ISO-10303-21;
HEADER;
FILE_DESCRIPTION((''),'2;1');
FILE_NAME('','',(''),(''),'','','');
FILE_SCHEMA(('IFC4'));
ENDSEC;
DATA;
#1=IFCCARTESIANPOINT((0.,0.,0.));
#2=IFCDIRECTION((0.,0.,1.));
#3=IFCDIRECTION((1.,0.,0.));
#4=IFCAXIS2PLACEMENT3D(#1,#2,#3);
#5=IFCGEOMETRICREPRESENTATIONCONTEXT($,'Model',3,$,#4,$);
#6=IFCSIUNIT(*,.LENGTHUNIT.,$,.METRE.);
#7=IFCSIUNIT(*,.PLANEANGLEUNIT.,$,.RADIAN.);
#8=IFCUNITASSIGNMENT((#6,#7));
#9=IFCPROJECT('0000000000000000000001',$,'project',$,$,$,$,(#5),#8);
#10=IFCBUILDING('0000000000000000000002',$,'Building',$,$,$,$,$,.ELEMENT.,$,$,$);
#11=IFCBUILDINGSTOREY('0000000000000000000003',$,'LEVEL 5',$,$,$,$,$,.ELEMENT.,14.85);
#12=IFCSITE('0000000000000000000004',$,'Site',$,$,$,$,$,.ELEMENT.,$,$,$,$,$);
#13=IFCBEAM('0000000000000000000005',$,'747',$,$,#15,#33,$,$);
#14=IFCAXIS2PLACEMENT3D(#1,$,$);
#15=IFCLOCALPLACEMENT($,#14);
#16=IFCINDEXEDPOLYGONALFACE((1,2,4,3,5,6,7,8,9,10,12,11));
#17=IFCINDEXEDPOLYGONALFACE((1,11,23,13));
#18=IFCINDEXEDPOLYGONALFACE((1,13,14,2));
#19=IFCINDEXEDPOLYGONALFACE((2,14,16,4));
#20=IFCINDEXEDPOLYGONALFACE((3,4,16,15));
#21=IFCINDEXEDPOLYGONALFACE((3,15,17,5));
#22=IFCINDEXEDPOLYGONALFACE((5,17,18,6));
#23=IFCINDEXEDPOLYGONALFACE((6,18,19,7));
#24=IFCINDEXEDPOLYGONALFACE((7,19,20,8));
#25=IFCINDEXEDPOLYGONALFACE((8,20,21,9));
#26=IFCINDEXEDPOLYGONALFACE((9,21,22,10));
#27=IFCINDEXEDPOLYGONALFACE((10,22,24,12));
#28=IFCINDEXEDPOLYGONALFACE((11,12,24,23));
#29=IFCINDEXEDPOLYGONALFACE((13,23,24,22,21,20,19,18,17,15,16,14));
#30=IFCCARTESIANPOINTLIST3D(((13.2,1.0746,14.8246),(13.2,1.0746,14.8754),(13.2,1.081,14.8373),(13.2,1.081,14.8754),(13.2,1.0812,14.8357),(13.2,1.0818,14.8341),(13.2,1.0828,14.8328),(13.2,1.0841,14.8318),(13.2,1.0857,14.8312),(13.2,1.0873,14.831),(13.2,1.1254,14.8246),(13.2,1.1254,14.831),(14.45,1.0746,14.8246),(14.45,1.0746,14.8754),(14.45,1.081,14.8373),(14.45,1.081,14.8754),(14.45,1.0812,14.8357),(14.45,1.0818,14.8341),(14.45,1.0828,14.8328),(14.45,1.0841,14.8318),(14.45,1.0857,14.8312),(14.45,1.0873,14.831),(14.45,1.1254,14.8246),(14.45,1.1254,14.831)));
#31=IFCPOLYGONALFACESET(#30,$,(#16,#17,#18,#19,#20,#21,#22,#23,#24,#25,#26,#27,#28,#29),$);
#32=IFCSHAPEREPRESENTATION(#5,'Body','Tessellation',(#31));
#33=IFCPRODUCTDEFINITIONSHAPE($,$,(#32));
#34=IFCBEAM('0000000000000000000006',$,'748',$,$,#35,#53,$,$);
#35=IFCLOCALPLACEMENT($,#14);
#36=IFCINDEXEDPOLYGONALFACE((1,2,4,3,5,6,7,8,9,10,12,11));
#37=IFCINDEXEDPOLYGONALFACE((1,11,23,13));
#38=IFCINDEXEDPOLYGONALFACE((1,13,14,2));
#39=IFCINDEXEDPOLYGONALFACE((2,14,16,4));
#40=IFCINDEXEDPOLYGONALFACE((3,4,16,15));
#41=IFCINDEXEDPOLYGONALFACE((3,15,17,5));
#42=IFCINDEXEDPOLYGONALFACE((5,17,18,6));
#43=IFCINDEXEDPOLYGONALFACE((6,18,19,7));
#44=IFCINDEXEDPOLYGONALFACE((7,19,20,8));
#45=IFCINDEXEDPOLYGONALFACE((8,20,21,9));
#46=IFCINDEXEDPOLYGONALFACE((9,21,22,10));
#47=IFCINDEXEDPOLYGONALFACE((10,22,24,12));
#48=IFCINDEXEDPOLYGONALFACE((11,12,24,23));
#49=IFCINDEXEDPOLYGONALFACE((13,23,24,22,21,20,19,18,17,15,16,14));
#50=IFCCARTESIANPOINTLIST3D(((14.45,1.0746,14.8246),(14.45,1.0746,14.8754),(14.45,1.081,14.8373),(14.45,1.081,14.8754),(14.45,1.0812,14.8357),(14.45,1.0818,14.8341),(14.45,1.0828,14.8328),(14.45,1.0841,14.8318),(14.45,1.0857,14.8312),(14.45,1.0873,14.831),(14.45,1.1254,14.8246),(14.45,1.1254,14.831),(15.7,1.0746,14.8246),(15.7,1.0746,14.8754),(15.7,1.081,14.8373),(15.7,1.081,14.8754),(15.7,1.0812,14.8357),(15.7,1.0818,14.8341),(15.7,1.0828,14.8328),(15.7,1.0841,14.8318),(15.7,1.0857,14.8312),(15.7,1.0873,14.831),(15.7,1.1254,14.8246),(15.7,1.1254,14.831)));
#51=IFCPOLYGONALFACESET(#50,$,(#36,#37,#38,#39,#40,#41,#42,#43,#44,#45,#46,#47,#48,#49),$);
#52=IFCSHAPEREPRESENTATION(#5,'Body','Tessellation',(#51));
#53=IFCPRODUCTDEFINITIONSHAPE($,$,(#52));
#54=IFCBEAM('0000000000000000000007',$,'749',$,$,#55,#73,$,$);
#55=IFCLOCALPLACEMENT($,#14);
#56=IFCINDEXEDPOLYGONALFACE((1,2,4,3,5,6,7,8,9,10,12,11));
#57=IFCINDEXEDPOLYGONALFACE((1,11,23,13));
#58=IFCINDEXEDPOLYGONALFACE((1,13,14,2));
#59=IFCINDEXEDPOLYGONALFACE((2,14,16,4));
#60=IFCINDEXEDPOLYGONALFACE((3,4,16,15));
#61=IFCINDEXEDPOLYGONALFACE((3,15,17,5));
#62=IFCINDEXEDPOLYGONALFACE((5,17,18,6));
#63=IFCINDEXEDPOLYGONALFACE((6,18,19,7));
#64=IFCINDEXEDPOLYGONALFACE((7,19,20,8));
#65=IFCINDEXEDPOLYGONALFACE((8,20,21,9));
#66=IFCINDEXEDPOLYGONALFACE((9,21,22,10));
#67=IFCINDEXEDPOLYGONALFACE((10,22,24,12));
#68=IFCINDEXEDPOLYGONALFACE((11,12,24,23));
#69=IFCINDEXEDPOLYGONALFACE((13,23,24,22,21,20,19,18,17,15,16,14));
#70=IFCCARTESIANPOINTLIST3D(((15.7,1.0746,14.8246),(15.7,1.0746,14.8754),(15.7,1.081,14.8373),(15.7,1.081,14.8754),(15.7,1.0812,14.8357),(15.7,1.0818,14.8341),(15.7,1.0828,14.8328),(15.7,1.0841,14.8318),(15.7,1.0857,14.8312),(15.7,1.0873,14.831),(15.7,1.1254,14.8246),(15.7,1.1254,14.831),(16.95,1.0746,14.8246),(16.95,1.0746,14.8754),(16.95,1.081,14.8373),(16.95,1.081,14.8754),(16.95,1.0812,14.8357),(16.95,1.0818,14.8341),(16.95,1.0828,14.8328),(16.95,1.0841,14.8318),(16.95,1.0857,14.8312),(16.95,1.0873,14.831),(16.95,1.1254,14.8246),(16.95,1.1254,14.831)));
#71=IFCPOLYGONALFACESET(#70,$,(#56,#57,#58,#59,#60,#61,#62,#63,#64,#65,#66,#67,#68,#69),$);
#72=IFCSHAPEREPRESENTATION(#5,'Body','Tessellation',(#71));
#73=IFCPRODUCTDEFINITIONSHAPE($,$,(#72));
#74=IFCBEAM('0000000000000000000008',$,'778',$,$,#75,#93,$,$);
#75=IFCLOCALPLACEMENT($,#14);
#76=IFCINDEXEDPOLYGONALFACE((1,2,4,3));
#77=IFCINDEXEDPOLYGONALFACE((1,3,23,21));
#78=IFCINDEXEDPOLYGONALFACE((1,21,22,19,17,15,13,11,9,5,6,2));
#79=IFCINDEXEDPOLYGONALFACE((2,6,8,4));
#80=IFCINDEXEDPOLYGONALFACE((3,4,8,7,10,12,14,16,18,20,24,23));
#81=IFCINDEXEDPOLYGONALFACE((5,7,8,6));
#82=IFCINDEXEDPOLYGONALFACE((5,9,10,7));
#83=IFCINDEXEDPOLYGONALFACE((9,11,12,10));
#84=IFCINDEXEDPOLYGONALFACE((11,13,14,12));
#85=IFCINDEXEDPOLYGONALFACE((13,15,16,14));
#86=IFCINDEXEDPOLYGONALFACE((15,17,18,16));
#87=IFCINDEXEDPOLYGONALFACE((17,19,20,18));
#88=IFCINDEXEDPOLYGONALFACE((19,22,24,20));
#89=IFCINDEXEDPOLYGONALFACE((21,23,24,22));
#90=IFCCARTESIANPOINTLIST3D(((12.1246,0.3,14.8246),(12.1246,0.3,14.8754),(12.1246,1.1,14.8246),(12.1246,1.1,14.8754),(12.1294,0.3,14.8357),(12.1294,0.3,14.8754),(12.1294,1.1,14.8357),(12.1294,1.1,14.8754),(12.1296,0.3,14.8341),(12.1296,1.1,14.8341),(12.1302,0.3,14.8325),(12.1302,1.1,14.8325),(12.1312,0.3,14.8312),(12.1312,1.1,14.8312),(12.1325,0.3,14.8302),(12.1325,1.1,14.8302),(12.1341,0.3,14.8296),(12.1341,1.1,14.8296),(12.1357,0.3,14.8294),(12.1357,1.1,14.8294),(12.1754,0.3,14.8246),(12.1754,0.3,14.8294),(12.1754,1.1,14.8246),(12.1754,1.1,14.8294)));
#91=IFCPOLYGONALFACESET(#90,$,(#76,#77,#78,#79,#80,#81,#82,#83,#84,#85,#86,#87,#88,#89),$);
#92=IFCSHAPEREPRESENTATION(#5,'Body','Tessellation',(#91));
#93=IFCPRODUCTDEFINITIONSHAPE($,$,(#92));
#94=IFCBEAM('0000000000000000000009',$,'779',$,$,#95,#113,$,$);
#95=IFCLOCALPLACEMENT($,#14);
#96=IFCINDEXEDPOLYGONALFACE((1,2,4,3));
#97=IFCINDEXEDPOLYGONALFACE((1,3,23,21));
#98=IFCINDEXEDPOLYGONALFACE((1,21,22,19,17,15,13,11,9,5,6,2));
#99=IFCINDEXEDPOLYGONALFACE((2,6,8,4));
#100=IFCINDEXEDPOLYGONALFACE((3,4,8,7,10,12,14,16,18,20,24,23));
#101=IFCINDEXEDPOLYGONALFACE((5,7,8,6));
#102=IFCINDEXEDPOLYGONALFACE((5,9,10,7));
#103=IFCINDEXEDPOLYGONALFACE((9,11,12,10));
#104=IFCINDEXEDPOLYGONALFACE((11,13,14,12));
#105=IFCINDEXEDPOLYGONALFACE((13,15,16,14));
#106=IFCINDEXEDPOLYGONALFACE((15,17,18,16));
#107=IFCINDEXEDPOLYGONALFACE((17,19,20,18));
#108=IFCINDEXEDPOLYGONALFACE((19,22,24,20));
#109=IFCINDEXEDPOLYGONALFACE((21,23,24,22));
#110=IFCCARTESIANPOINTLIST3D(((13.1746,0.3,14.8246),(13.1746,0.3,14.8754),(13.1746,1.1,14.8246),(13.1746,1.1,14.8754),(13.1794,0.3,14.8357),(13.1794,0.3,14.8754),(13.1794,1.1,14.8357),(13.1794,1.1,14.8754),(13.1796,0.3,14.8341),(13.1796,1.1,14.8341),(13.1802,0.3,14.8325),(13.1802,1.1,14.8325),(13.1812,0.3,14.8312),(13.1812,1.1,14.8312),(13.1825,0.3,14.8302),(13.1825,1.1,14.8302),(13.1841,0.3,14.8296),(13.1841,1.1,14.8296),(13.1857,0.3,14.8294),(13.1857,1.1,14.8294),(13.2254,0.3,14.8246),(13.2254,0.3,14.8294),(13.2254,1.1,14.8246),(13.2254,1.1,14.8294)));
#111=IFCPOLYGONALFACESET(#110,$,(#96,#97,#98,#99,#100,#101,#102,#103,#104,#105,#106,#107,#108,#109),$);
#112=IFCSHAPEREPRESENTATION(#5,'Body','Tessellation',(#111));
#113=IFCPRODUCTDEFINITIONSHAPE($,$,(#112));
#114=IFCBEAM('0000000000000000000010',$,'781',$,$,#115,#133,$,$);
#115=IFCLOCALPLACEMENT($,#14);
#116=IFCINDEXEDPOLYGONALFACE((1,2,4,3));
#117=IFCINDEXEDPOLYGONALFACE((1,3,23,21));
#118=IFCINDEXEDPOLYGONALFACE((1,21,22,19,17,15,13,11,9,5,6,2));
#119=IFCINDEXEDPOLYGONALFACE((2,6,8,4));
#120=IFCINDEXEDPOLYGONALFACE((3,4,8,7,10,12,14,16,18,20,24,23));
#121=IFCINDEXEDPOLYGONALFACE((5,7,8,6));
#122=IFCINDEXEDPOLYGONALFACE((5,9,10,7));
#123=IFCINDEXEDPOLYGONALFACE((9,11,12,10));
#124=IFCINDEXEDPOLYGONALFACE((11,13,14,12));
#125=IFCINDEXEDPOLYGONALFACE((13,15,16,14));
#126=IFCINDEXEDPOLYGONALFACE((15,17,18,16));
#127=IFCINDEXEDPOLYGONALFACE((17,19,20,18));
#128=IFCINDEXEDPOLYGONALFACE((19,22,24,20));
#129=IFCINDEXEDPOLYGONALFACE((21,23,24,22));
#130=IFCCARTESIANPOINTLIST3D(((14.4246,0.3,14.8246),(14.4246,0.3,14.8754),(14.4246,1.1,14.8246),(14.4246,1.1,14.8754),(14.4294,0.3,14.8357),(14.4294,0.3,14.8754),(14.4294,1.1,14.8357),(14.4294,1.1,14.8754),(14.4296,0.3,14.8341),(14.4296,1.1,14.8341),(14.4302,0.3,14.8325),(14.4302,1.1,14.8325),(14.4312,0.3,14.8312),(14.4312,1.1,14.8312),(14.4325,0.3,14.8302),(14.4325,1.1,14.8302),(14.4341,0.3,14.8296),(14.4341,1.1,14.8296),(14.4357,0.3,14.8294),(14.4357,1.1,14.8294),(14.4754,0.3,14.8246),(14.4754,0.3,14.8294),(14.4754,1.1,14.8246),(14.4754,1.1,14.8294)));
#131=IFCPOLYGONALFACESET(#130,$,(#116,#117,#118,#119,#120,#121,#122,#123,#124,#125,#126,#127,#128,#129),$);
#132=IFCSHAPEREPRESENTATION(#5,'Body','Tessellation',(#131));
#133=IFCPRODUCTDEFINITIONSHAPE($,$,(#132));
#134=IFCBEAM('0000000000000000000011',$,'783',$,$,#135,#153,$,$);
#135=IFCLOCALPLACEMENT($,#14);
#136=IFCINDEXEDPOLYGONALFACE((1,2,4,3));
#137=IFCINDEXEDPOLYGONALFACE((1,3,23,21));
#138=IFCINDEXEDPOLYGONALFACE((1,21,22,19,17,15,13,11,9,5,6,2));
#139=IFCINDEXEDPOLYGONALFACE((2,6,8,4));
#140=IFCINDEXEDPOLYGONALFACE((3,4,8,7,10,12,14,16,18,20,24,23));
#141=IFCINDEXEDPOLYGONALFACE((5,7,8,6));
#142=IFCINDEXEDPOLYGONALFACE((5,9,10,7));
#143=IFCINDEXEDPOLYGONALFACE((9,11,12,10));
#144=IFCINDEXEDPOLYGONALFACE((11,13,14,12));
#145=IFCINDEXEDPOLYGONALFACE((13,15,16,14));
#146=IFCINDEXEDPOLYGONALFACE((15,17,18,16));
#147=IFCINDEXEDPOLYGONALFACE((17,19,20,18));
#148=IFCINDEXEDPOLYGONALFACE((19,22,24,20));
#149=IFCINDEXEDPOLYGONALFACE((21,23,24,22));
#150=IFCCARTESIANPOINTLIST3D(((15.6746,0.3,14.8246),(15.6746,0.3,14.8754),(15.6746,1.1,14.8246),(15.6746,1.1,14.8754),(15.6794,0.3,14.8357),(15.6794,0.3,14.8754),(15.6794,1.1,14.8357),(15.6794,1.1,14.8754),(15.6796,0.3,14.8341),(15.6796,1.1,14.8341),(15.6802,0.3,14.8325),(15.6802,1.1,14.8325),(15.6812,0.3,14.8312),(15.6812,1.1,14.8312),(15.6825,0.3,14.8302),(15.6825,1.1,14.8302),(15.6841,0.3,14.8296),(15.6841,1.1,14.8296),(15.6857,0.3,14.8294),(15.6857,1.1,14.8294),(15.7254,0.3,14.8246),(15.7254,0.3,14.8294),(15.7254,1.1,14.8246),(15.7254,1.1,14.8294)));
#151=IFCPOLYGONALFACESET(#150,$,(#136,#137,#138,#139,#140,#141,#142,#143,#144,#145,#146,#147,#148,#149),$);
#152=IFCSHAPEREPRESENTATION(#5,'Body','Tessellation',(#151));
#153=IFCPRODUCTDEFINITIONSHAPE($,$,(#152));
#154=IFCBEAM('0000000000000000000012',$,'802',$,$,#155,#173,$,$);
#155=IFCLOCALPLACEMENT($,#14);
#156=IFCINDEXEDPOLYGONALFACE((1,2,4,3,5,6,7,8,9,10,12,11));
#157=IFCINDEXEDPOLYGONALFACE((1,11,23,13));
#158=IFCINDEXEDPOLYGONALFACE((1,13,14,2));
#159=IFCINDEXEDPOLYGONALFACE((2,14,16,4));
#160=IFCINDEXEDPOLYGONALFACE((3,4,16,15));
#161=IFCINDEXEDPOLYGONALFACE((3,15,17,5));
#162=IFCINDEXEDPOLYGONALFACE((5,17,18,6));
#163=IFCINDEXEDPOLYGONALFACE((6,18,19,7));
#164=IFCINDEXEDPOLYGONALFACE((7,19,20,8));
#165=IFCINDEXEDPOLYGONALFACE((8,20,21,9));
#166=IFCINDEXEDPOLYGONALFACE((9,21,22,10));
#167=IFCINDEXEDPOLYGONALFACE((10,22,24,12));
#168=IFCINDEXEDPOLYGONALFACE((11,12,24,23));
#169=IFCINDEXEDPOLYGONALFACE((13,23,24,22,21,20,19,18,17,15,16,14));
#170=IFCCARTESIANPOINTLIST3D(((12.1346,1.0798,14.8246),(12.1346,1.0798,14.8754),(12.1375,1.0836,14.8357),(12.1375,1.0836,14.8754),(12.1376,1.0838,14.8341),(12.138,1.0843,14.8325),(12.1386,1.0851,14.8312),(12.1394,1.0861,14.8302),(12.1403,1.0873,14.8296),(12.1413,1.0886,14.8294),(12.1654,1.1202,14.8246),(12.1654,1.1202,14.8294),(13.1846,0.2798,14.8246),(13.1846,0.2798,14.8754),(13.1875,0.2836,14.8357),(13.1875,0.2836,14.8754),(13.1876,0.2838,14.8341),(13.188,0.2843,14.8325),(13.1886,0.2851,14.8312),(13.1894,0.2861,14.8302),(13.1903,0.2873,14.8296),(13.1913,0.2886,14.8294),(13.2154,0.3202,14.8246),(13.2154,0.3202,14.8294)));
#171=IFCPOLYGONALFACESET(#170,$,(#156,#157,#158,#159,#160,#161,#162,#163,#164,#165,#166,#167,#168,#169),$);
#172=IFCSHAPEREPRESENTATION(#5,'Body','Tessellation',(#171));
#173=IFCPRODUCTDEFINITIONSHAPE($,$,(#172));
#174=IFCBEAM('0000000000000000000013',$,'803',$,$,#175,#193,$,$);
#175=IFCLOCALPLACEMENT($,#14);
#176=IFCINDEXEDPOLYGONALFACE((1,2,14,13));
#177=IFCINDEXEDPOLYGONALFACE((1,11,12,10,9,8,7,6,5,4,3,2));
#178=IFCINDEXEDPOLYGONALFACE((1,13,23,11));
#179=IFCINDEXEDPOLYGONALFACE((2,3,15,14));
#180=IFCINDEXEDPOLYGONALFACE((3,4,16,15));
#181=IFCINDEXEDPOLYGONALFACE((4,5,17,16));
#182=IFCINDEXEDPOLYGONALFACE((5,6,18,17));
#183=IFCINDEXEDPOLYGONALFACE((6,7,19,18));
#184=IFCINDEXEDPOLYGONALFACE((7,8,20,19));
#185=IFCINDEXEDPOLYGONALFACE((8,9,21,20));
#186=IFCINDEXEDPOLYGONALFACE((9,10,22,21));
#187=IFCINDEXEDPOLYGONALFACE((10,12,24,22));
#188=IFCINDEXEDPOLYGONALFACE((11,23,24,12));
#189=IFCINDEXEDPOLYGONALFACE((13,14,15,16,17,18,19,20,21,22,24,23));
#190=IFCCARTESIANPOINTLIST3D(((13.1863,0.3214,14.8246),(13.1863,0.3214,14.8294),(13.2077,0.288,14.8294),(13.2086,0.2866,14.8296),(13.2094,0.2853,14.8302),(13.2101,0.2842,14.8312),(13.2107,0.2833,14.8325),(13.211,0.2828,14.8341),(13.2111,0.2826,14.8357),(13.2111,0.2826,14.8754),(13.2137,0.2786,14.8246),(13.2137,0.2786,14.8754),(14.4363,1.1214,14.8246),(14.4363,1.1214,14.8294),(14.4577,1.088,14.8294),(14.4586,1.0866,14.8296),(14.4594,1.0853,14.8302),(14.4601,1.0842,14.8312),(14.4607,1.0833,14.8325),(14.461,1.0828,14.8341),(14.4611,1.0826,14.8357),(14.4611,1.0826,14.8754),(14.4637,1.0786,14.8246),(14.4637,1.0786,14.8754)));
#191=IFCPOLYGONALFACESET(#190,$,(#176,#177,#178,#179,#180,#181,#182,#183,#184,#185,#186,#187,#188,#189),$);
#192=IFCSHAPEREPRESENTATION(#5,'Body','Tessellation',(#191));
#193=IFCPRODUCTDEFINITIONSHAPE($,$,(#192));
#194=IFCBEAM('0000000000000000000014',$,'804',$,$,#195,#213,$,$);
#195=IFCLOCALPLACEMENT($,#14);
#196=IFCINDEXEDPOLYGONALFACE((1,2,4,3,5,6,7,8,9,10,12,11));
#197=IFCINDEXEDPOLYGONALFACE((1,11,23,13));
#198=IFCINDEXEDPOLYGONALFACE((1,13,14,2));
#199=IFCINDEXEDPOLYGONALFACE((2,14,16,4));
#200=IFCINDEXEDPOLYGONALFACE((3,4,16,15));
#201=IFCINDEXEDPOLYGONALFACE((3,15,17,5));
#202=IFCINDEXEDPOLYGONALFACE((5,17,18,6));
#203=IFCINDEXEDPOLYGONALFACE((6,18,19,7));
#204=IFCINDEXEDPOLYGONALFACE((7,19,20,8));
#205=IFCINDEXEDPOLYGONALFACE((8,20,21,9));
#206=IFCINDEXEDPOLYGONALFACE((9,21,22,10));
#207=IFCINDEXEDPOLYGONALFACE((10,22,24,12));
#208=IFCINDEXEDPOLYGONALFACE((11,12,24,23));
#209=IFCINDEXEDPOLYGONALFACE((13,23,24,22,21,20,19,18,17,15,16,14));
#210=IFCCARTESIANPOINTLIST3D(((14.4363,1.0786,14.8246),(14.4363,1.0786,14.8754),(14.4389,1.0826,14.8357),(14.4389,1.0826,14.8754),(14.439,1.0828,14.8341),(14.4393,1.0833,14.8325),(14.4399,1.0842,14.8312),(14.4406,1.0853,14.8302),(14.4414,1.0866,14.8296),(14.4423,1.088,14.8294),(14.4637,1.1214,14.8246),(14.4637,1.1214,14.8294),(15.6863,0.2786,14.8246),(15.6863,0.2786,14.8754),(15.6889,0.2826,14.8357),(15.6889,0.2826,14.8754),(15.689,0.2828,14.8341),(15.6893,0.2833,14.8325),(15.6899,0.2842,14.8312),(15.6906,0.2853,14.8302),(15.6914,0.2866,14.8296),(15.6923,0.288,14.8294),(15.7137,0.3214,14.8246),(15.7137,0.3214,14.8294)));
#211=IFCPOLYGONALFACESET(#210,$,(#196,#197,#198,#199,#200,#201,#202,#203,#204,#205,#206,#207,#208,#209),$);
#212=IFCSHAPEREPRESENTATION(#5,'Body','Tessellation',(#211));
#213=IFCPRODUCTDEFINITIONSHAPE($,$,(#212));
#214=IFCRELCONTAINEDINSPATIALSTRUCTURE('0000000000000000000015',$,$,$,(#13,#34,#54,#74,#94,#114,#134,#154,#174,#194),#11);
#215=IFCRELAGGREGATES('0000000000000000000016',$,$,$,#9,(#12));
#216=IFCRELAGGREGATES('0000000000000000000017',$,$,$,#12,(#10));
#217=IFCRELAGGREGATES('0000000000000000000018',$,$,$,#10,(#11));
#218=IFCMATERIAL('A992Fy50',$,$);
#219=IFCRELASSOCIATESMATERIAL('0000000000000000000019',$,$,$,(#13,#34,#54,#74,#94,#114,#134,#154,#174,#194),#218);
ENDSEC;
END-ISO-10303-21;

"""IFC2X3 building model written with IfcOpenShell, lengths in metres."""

from ifc_helpers import new_model, si_unit, frame, origin_with_axes, origin_2d_with_axis, place, context, project, spatial, l_section, extrude, material, element, save


model = new_model("IFC2X3")

# Units and contexts
model_context = context("Model", 3, world=origin_with_axes())
ifc_project = project(units=[si_unit("LENGTHUNIT", "METRE"), si_unit("PLANEANGLEUNIT", "RADIAN")], contexts=[model_context])

# Site, building, storey
site = spatial("IfcSite", under=ifc_project, Name="Site", CompositionType="ELEMENT")
building = spatial("IfcBuilding", under=site, Name="Building", CompositionType="ELEMENT")
storey = spatial("IfcBuildingStorey", under=building, Name="LEVEL 5", CompositionType="ELEMENT", Elevation=14.85)

# Beams
ifc_material = material(Name="A992Fy50")
for number, where, z_axis, x_axis, name in (
    (1, (13.2, 1.1, 14.85), (1.0, 0.0, 0.0), (0.0, 1.0, 0.0), "747"),
    (2, (14.45, 1.1, 14.85), (1.0, 0.0, 0.0), (0.0, 1.0, 0.0), "748"),
    (3, (15.7, 1.1, 14.85), (1.0, 0.0, 0.0), (0.0, 1.0, 0.0), "749"),
):
    element("IfcBeam", number, at=place(None, frame(where, z_axis=z_axis, x_axis=x_axis)), inside=storey, material=ifc_material, Name=name, context=model_context, shape_type="SweptSolid", body=[
        extrude(l_section(Depth=0.0508, Width=0.0508, Thickness=0.0063, FilletRadius=0.0063, at=origin_2d_with_axis()), origin_with_axes(), (0.0, 0.0, 1.0), 1.25),
    ])
for number, where, z_axis, x_axis, name in (
    (4, (12.15, 1.1, 14.85), (0.0, -1.0, 0.0), (1.0, 0.0, 0.0), "778"),
    (5, (13.2, 1.1, 14.85), (0.0, -1.0, 0.0), (1.0, 0.0, 0.0), "779"),
    (6, (14.45, 1.1, 14.85), (0.0, -1.0, 0.0), (1.0, 0.0, 0.0), "781"),
    (7, (15.7, 1.1, 14.85), (0.0, -1.0, 0.0), (1.0, 0.0, 0.0), "783"),
):
    element("IfcBeam", number, at=place(None, frame(where, z_axis=z_axis, x_axis=x_axis)), inside=storey, material=ifc_material, Name=name, context=model_context, shape_type="SweptSolid", body=[
        extrude(l_section(Depth=0.0508, Width=0.0508, Thickness=0.0048, FilletRadius=0.0063, at=origin_2d_with_axis()), origin_with_axes(), (0.0, 0.0, 1.0), 0.8),
    ])
beam_1_placement = place(None, frame((12.15, 1.1, 14.85), z_axis=(0.795432, -0.606043, 0.0), x_axis=(0.606043, 0.795432, 0.0)))
element("IfcBeam", 8, at=beam_1_placement, inside=storey, material=ifc_material, Name="802", context=model_context, shape_type="SweptSolid", body=[
    extrude(l_section(Depth=0.0508, Width=0.0508, Thickness=0.0048, FilletRadius=0.0063, at=origin_2d_with_axis()), origin_with_axes(), (0.0, 0.0, 1.0), 1.32),
])
for number, where, z_axis, x_axis, name in (
    (9, (13.2, 0.3, 14.85), (0.842271, 0.539054, 0.0), (-0.539054, 0.842271, 0.0), "803"),
    (10, (14.45, 1.1, 14.85), (0.842271, -0.539054, 0.0), (0.539054, 0.842271, 0.0), "804"),
):
    element("IfcBeam", number, at=place(None, frame(where, z_axis=z_axis, x_axis=x_axis)), inside=storey, material=ifc_material, Name=name, context=model_context, shape_type="SweptSolid", body=[
        extrude(l_section(Depth=0.0508, Width=0.0508, Thickness=0.0048, FilletRadius=0.0063, at=origin_2d_with_axis()), origin_with_axes(), (0.0, 0.0, 1.0), 1.4841),
    ])

save(model, "model.ifc")
